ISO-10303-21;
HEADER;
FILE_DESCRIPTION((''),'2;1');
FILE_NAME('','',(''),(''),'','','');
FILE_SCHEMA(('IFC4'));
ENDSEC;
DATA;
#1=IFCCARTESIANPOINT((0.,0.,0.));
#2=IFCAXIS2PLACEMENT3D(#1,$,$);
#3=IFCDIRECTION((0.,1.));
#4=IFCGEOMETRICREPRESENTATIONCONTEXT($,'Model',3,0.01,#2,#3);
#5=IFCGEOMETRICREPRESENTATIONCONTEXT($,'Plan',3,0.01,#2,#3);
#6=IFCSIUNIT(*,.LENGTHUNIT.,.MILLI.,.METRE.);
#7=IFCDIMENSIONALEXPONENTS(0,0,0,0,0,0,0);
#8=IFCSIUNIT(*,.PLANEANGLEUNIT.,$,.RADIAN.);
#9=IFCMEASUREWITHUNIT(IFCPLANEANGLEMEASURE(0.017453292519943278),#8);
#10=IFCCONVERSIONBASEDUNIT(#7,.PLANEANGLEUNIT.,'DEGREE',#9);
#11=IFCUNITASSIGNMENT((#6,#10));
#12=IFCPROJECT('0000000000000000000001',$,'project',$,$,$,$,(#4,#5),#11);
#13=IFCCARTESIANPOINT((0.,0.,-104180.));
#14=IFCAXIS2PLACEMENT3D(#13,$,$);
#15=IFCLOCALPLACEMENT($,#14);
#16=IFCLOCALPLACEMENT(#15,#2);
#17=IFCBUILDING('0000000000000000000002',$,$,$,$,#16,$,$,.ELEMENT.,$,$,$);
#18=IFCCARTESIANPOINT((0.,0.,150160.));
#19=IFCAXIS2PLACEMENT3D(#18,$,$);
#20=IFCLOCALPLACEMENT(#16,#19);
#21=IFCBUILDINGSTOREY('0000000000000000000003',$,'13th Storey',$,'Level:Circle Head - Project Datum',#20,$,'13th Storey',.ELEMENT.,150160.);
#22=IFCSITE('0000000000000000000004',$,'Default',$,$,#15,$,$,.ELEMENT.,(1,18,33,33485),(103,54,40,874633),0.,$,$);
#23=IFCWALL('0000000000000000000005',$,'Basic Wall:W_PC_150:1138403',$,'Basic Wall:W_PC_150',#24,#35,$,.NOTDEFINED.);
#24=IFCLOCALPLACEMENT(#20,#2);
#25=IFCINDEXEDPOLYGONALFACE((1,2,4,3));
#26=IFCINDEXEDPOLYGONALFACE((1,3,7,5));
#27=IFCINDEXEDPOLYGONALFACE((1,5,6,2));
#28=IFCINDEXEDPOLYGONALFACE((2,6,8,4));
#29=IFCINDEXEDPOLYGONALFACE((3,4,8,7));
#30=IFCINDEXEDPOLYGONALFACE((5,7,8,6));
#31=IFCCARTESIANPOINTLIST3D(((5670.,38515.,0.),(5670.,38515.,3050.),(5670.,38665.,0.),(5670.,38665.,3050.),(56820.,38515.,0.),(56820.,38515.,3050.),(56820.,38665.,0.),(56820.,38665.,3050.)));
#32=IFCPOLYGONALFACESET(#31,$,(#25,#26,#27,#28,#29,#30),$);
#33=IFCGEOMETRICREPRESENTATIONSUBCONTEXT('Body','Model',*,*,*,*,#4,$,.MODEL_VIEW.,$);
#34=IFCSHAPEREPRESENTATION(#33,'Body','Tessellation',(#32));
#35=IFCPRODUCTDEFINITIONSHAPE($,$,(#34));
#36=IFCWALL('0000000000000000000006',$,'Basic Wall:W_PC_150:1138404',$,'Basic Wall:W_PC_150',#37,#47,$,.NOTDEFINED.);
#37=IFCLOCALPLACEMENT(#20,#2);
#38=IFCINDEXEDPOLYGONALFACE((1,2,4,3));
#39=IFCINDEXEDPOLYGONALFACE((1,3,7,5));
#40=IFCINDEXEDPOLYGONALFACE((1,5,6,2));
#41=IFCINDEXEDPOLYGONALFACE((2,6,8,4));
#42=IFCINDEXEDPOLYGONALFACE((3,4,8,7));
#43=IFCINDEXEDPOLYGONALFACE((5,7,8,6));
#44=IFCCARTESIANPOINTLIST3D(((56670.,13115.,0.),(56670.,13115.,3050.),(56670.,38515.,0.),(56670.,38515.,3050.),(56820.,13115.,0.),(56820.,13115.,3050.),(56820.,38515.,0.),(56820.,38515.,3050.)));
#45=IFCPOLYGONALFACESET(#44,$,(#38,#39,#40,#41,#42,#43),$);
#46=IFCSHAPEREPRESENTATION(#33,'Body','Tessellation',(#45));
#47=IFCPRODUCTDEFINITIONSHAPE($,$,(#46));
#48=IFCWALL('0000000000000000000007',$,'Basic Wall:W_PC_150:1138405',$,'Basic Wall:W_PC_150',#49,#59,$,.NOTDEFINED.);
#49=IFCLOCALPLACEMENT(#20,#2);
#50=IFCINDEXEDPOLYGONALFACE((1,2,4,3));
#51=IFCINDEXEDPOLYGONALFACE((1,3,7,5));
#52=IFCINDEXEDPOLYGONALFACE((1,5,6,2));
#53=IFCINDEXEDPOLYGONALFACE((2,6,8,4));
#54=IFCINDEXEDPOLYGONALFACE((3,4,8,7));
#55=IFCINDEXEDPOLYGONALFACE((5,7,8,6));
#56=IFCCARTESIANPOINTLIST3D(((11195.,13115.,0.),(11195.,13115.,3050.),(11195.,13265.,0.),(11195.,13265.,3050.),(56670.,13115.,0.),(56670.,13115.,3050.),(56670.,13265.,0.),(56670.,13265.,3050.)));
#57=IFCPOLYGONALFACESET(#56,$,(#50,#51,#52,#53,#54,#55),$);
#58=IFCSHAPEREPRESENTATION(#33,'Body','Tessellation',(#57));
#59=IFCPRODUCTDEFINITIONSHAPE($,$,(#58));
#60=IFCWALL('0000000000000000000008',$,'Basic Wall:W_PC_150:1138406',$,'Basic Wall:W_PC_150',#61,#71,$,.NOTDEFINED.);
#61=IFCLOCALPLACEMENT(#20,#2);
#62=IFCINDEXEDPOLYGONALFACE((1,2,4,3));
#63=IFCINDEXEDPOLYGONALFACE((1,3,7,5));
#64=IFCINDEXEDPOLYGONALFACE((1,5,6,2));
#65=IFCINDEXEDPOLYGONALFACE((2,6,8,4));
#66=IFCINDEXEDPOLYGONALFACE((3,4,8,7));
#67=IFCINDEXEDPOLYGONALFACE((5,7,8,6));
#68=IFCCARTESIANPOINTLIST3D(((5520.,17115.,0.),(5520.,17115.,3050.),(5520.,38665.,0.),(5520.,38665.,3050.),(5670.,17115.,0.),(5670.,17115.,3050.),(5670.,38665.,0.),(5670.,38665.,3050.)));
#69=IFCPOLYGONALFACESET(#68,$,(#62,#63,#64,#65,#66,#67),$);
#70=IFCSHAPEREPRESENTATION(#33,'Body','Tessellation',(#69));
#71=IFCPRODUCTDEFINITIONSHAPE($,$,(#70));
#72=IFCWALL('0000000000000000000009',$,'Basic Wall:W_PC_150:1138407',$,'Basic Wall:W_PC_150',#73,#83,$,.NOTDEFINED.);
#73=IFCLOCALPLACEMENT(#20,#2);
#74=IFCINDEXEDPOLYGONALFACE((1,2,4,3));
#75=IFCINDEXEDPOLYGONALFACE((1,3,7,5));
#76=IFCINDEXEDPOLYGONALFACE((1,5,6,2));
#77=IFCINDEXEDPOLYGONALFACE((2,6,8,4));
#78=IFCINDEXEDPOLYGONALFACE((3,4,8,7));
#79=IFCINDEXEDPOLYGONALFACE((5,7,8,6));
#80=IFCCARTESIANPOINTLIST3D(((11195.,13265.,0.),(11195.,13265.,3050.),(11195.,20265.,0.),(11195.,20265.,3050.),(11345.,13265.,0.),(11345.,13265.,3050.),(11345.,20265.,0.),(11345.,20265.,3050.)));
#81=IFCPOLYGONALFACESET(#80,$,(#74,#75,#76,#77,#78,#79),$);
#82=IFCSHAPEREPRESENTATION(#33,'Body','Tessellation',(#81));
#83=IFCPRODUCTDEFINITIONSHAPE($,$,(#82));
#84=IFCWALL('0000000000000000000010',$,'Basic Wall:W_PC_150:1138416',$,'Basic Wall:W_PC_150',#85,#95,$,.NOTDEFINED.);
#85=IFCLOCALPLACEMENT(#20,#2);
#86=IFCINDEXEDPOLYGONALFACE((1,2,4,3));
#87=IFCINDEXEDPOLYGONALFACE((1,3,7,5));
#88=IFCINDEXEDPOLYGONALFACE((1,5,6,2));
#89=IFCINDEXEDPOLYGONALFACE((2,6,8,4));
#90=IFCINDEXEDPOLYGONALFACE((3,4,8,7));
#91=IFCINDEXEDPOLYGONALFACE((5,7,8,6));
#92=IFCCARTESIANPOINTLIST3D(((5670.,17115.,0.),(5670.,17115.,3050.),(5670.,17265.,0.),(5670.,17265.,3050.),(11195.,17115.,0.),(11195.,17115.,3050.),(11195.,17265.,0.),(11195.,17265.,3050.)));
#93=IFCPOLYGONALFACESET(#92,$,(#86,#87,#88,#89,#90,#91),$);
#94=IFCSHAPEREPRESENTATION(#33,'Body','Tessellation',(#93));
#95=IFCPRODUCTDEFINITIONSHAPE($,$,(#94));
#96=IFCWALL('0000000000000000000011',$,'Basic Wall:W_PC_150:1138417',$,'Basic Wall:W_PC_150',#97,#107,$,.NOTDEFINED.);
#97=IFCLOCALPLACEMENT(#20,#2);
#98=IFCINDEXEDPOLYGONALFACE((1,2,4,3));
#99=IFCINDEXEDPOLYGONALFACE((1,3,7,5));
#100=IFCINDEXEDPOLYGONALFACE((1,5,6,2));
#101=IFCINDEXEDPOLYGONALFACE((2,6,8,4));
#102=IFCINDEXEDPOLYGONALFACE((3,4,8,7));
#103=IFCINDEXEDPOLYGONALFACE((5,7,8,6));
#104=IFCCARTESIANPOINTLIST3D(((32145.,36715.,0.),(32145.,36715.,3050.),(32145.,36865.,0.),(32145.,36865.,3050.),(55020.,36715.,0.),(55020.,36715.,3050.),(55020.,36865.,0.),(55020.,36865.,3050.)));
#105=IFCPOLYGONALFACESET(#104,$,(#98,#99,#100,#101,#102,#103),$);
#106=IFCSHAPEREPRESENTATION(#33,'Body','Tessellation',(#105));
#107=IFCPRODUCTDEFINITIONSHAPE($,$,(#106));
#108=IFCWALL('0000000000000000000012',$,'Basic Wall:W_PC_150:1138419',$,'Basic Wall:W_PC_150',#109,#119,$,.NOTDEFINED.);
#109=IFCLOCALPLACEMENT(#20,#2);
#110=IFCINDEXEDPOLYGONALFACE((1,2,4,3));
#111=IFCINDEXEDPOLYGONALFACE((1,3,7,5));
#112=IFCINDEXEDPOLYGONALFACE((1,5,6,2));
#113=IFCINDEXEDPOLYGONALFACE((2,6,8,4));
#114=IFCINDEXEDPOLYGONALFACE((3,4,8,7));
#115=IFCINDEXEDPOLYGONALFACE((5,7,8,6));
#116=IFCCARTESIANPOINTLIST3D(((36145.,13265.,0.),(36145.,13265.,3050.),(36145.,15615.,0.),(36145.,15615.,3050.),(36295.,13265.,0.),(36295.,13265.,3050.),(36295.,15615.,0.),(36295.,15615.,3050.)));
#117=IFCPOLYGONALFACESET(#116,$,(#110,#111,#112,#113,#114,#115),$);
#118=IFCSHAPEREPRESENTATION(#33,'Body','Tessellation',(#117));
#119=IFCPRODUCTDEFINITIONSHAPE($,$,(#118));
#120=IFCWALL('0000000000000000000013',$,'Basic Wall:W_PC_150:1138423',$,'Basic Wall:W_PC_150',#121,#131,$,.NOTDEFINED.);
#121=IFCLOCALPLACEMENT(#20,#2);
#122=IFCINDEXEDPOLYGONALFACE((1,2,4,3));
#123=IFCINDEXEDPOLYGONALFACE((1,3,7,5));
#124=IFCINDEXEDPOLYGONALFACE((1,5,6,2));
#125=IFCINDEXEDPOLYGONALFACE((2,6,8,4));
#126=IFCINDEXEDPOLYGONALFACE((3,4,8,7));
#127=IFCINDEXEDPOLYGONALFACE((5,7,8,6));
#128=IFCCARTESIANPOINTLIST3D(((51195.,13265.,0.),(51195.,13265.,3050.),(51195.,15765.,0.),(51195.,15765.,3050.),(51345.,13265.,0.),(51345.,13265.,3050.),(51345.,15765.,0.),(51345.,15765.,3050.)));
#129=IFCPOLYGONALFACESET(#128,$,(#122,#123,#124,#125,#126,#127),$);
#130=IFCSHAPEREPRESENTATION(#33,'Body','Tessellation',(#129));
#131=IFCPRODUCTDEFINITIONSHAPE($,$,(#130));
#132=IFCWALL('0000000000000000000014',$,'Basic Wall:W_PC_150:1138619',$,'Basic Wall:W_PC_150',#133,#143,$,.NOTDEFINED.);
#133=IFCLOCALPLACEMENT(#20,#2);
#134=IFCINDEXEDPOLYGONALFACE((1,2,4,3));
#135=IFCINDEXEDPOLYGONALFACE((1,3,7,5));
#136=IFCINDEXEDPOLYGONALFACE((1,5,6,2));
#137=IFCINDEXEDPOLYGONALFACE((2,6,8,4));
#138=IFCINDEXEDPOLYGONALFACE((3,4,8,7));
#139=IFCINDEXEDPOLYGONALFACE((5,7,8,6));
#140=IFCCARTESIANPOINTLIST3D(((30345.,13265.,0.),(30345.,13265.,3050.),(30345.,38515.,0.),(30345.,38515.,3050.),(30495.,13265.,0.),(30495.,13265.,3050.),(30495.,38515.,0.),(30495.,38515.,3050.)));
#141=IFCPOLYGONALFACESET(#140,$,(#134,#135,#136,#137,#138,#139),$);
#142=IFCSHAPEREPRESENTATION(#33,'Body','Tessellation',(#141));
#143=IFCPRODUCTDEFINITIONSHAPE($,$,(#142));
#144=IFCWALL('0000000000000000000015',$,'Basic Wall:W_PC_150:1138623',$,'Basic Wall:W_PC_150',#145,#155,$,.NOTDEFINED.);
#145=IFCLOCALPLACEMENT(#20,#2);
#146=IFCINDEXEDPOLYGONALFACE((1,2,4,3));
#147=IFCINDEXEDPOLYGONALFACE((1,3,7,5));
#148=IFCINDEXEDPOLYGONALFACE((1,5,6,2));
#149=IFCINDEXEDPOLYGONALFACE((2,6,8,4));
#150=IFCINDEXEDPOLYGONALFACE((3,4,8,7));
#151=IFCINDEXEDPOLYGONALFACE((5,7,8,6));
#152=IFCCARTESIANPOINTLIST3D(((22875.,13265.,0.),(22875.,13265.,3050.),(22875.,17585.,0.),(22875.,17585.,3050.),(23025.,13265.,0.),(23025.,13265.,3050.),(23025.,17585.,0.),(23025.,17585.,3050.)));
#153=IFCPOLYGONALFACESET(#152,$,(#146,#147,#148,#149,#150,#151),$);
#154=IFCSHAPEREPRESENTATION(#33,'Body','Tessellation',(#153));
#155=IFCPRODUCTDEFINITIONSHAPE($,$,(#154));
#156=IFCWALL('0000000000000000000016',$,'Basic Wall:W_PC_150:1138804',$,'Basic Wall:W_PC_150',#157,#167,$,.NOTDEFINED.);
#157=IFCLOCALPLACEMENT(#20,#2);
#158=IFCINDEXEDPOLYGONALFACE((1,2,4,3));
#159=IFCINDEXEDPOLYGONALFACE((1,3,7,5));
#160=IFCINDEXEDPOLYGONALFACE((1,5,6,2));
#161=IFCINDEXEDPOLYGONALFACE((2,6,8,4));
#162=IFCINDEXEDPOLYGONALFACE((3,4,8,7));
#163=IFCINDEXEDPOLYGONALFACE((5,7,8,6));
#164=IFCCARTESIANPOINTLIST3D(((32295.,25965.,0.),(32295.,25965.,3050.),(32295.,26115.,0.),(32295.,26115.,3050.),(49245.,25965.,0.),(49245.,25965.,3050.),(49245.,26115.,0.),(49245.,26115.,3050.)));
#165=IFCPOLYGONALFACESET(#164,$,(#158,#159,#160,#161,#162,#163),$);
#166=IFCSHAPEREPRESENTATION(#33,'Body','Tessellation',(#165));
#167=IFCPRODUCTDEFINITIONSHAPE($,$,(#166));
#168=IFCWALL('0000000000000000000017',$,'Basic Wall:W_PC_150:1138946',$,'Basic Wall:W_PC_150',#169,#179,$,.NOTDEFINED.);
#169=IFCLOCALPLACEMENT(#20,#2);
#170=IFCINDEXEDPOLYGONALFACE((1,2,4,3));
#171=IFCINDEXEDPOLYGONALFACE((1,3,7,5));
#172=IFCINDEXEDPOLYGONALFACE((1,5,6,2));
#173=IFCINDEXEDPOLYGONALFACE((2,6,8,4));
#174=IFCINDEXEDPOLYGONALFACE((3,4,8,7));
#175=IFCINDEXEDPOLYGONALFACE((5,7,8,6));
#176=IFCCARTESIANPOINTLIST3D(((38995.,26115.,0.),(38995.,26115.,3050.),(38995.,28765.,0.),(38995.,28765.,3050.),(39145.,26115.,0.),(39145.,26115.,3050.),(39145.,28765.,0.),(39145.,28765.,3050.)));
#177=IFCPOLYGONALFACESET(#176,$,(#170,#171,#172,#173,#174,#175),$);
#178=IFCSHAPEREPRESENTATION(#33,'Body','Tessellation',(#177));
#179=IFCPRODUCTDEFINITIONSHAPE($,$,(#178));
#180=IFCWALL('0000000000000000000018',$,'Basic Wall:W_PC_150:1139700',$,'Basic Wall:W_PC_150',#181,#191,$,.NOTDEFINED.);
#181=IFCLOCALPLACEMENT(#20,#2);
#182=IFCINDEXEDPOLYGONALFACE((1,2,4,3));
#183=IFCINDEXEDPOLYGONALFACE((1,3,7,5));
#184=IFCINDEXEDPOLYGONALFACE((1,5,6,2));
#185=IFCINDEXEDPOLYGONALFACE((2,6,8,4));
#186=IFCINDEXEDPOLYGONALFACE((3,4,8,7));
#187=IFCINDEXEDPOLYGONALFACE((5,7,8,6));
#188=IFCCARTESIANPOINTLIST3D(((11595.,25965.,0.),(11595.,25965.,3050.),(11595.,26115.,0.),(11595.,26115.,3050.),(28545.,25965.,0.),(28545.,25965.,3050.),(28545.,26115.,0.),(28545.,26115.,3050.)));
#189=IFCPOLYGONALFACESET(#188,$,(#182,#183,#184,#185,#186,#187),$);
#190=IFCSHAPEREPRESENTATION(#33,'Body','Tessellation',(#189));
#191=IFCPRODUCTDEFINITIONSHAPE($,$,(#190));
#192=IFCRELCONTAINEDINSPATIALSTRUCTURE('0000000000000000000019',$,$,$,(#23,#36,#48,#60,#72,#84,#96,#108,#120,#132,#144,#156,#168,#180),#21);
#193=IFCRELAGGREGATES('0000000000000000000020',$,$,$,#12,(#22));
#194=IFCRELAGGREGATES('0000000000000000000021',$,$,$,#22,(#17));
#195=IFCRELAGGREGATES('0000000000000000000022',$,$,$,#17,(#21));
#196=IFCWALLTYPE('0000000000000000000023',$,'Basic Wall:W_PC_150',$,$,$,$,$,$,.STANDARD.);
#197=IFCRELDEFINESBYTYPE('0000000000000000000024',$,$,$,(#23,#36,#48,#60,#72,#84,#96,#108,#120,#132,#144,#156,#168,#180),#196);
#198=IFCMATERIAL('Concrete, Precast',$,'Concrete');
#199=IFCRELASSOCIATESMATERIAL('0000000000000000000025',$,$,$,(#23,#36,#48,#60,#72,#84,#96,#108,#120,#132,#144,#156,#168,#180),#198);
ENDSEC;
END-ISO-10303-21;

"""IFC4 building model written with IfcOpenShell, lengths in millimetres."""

from ifc_helpers import new_model, entity, si_unit, converted_unit, direction, frame, origin, place, context, subcontext, project, spatial, indexed_curve, outline, extrude, material, type_object, element, save


model = new_model("IFC4")

# Units and contexts
model_context = context("Model", 3, precision=0.01, world=origin(), true_north=direction((0.0, 1.0)))
plan_context = context("Plan", 3, precision=0.01, world=origin(), true_north=direction((0.0, 1.0)))
body_context = subcontext(model_context, "Body", "Model", "MODEL_VIEW")
ifc_project = project(units=[si_unit("LENGTHUNIT", "METRE", prefix="MILLI"), converted_unit("PLANEANGLEUNIT", "DEGREE", entity("IfcPlaneAngleMeasure", 0.017453292519943278), si_unit("PLANEANGLEUNIT", "RADIAN"), dimensions=[0, 0, 0, 0, 0, 0, 0])], contexts=[model_context, plan_context])

# Site, building, storey
site_placement = place(None, frame((0.0, 0.0, -104180.0)))
site = spatial("IfcSite", under=ifc_project, at=site_placement, Name="Default", CompositionType="ELEMENT", RefLatitude=(1, 18, 33, 33485), RefLongitude=(103, 54, 40, 874633), RefElevation=0.0)
building_placement = place(site_placement, origin())
building = spatial("IfcBuilding", under=site, at=building_placement, CompositionType="ELEMENT")
storey_placement = place(building_placement, frame((0.0, 0.0, 150160.0)))
storey = spatial("IfcBuildingStorey", under=building, at=storey_placement, Name="13th Storey", ObjectType="Level:Circle Head - Project Datum", LongName="13th Storey", CompositionType="ELEMENT", Elevation=150160.0)

# Shared definitions
ifc_material_1 = material(Name="Concrete, Precast", Category="Concrete")

# Walls
wall_type = type_object("IfcWallType", Name="Basic Wall:W_PC_150", PredefinedType="STANDARD")
wall_1_placement = place(storey_placement, frame((56820.0, 38590.0, 0.0), z_axis=(0.0, 0.0, 1.0), x_axis=(-1.0, 0.0, 0.0)))
element("IfcWall", 1, at=wall_1_placement, inside=storey, type_object=wall_type, material=ifc_material_1, Name="Basic Wall:W_PC_150:1138403", ObjectType="Basic Wall:W_PC_150", PredefinedType="NOTDEFINED", context=body_context, shape_type="SweptSolid", body=[
    extrude(outline(indexed_curve([(51150.0, 75.0), (0.0, 75.0), (0.0, -75.0), (51150.0, -75.0), (51150.0, 75.0)], self_intersect=False)), origin(), (0.0, 0.0, 1.0), 3050.0),
])
wall_2_placement = place(storey_placement, frame((56745.0, 13115.0, 0.0), z_axis=(0.0, 0.0, 1.0), x_axis=(0.0, 1.0, 0.0)))
element("IfcWall", 2, at=wall_2_placement, inside=storey, type_object=wall_type, material=ifc_material_1, Name="Basic Wall:W_PC_150:1138404", ObjectType="Basic Wall:W_PC_150", PredefinedType="NOTDEFINED", context=body_context, shape_type="SweptSolid", body=[
    extrude(outline(indexed_curve([(25400.0, 75.0), (0.0, 75.0), (0.0, -75.0), (25400.0, -75.0), (25400.0, 75.0)], self_intersect=False)), origin(), (0.0, 0.0, 1.0), 3050.0),
])
wall_3_placement = place(storey_placement, frame((11195.0, 13190.0, 0.0)))
element("IfcWall", 3, at=wall_3_placement, inside=storey, type_object=wall_type, material=ifc_material_1, Name="Basic Wall:W_PC_150:1138405", ObjectType="Basic Wall:W_PC_150", PredefinedType="NOTDEFINED", context=body_context, shape_type="SweptSolid", body=[
    extrude(outline(indexed_curve([(45475.0, 75.0), (0.0, 75.0), (0.0, -75.0), (45475.0, -75.0), (45475.0, 75.0)], self_intersect=False)), origin(), (0.0, 0.0, 1.0), 3050.0),
])
wall_4_placement = place(storey_placement, frame((5595.0, 38665.0, 0.0), z_axis=(0.0, 0.0, 1.0), x_axis=(0.0, -1.0, 0.0)))
element("IfcWall", 4, at=wall_4_placement, inside=storey, type_object=wall_type, material=ifc_material_1, Name="Basic Wall:W_PC_150:1138406", ObjectType="Basic Wall:W_PC_150", PredefinedType="NOTDEFINED", context=body_context, shape_type="SweptSolid", body=[
    extrude(outline(indexed_curve([(21550.0, 75.0), (0.0, 75.0), (0.0, -75.0), (21550.0, -75.0), (21550.0, 75.0)], self_intersect=False)), origin(), (0.0, 0.0, 1.0), 3050.0),
])
wall_5_placement = place(storey_placement, frame((11270.0, 20265.0, 0.0), z_axis=(0.0, 0.0, 1.0), x_axis=(0.0, -1.0, 0.0)))
element("IfcWall", 5, at=wall_5_placement, inside=storey, type_object=wall_type, material=ifc_material_1, Name="Basic Wall:W_PC_150:1138407", ObjectType="Basic Wall:W_PC_150", PredefinedType="NOTDEFINED", context=body_context, shape_type="SweptSolid", body=[
    extrude(outline(indexed_curve([(7000.0, 75.0), (0.0, 75.0), (0.0, -75.0), (7000.0, -75.0), (7000.0, 75.0)], self_intersect=False)), origin(), (0.0, 0.0, 1.0), 3050.0),
])
wall_6_placement = place(storey_placement, frame((5670.0, 17190.0, 0.0)))
element("IfcWall", 6, at=wall_6_placement, inside=storey, type_object=wall_type, material=ifc_material_1, Name="Basic Wall:W_PC_150:1138416", ObjectType="Basic Wall:W_PC_150", PredefinedType="NOTDEFINED", context=body_context, shape_type="SweptSolid", body=[
    extrude(outline(indexed_curve([(5525.0, 75.0), (0.0, 75.0), (0.0, -75.0), (5525.0, -75.0), (5525.0, 75.0)], self_intersect=False)), origin(), (0.0, 0.0, 1.0), 3050.0),
])
wall_7_placement = place(storey_placement, frame((55020.0, 36790.0, 0.0), z_axis=(0.0, 0.0, 1.0), x_axis=(-1.0, 0.0, 0.0)))
element("IfcWall", 7, at=wall_7_placement, inside=storey, type_object=wall_type, material=ifc_material_1, Name="Basic Wall:W_PC_150:1138417", ObjectType="Basic Wall:W_PC_150", PredefinedType="NOTDEFINED", context=body_context, shape_type="SweptSolid", body=[
    extrude(outline(indexed_curve([(22875.0, 75.0), (0.0, 75.0), (0.0, -75.0), (22875.0, -75.0), (22875.0, 75.0)], self_intersect=False)), origin(), (0.0, 0.0, 1.0), 3050.0),
])
wall_8_placement = place(storey_placement, frame((36220.0, 13265.0, 0.0), z_axis=(0.0, 0.0, 1.0), x_axis=(0.0, 1.0, 0.0)))
element("IfcWall", 8, at=wall_8_placement, inside=storey, type_object=wall_type, material=ifc_material_1, Name="Basic Wall:W_PC_150:1138419", ObjectType="Basic Wall:W_PC_150", PredefinedType="NOTDEFINED", context=body_context, shape_type="SweptSolid", body=[
    extrude(outline(indexed_curve([(2350.0, 75.0), (0.0, 75.0), (0.0, -75.0), (2350.0, -75.0), (2350.0, 75.0)], self_intersect=False)), origin(), (0.0, 0.0, 1.0), 3050.0),
])
wall_9_placement = place(storey_placement, frame((51270.0, 13265.0, 0.0), z_axis=(0.0, 0.0, 1.0), x_axis=(0.0, 1.0, 0.0)))
element("IfcWall", 9, at=wall_9_placement, inside=storey, type_object=wall_type, material=ifc_material_1, Name="Basic Wall:W_PC_150:1138423", ObjectType="Basic Wall:W_PC_150", PredefinedType="NOTDEFINED", context=body_context, shape_type="SweptSolid", body=[
    extrude(outline(indexed_curve([(2500.0, 75.0), (0.0, 75.0), (0.0, -75.0), (2500.0, -75.0), (2500.0, 75.0)], self_intersect=False)), origin(), (0.0, 0.0, 1.0), 3050.0),
])
wall_10_placement = place(storey_placement, frame((30420.0, 13265.0, 0.0), z_axis=(0.0, 0.0, 1.0), x_axis=(0.0, 1.0, 0.0)))
element("IfcWall", 10, at=wall_10_placement, inside=storey, type_object=wall_type, material=ifc_material_1, Name="Basic Wall:W_PC_150:1138619", ObjectType="Basic Wall:W_PC_150", PredefinedType="NOTDEFINED", context=body_context, shape_type="SweptSolid", body=[
    extrude(outline(indexed_curve([(25250.0, 75.0), (0.0, 75.0), (0.0, -75.0), (25250.0, -75.0), (25250.0, 75.0)], self_intersect=False)), origin(), (0.0, 0.0, 1.0), 3050.0),
])
wall_11_placement = place(storey_placement, frame((22950.0, 13265.0, 0.0), z_axis=(0.0, 0.0, 1.0), x_axis=(0.0, 1.0, 0.0)))
element("IfcWall", 11, at=wall_11_placement, inside=storey, type_object=wall_type, material=ifc_material_1, Name="Basic Wall:W_PC_150:1138623", ObjectType="Basic Wall:W_PC_150", PredefinedType="NOTDEFINED", context=body_context, shape_type="SweptSolid", body=[
    extrude(outline(indexed_curve([(4320.0, 75.0), (0.0, 75.0), (0.0, -75.0), (4320.0, -75.0), (4320.0, 75.0)], self_intersect=False)), origin(), (0.0, 0.0, 1.0), 3050.0),
])
wall_12_placement = place(storey_placement, frame((49245.0, 26040.0, 0.0), z_axis=(0.0, 0.0, 1.0), x_axis=(-1.0, 0.0, 0.0)))
element("IfcWall", 12, at=wall_12_placement, inside=storey, type_object=wall_type, material=ifc_material_1, Name="Basic Wall:W_PC_150:1138804", ObjectType="Basic Wall:W_PC_150", PredefinedType="NOTDEFINED", context=body_context, shape_type="SweptSolid", body=[
    extrude(outline(indexed_curve([(16950.0, 75.0), (0.0, 75.0), (0.0, -75.0), (16950.0, -75.0), (16950.0, 75.0)], self_intersect=False)), origin(), (0.0, 0.0, 1.0), 3050.0),
])
wall_13_placement = place(storey_placement, frame((39070.0, 26115.0, 0.0), z_axis=(0.0, 0.0, 1.0), x_axis=(0.0, 1.0, 0.0)))
element("IfcWall", 13, at=wall_13_placement, inside=storey, type_object=wall_type, material=ifc_material_1, Name="Basic Wall:W_PC_150:1138946", ObjectType="Basic Wall:W_PC_150", PredefinedType="NOTDEFINED", context=body_context, shape_type="SweptSolid", body=[
    extrude(outline(indexed_curve([(2650.0, 75.0), (0.0, 75.0), (0.0, -75.0), (2650.0, -75.0), (2650.0, 75.0)], self_intersect=False)), origin(), (0.0, 0.0, 1.0), 3050.0),
])
wall_14_placement = place(storey_placement, frame((11595.0, 26040.0, 0.0)))
element("IfcWall", 14, at=wall_14_placement, inside=storey, type_object=wall_type, material=ifc_material_1, Name="Basic Wall:W_PC_150:1139700", ObjectType="Basic Wall:W_PC_150", PredefinedType="NOTDEFINED", context=body_context, shape_type="SweptSolid", body=[
    extrude(outline(indexed_curve([(16950.0, 75.0), (0.0, 75.0), (0.0, -75.0), (16950.0, -75.0), (16950.0, 75.0)], self_intersect=False)), origin(), (0.0, 0.0, 1.0), 3050.0),
])

save(model, "model.ifc")
